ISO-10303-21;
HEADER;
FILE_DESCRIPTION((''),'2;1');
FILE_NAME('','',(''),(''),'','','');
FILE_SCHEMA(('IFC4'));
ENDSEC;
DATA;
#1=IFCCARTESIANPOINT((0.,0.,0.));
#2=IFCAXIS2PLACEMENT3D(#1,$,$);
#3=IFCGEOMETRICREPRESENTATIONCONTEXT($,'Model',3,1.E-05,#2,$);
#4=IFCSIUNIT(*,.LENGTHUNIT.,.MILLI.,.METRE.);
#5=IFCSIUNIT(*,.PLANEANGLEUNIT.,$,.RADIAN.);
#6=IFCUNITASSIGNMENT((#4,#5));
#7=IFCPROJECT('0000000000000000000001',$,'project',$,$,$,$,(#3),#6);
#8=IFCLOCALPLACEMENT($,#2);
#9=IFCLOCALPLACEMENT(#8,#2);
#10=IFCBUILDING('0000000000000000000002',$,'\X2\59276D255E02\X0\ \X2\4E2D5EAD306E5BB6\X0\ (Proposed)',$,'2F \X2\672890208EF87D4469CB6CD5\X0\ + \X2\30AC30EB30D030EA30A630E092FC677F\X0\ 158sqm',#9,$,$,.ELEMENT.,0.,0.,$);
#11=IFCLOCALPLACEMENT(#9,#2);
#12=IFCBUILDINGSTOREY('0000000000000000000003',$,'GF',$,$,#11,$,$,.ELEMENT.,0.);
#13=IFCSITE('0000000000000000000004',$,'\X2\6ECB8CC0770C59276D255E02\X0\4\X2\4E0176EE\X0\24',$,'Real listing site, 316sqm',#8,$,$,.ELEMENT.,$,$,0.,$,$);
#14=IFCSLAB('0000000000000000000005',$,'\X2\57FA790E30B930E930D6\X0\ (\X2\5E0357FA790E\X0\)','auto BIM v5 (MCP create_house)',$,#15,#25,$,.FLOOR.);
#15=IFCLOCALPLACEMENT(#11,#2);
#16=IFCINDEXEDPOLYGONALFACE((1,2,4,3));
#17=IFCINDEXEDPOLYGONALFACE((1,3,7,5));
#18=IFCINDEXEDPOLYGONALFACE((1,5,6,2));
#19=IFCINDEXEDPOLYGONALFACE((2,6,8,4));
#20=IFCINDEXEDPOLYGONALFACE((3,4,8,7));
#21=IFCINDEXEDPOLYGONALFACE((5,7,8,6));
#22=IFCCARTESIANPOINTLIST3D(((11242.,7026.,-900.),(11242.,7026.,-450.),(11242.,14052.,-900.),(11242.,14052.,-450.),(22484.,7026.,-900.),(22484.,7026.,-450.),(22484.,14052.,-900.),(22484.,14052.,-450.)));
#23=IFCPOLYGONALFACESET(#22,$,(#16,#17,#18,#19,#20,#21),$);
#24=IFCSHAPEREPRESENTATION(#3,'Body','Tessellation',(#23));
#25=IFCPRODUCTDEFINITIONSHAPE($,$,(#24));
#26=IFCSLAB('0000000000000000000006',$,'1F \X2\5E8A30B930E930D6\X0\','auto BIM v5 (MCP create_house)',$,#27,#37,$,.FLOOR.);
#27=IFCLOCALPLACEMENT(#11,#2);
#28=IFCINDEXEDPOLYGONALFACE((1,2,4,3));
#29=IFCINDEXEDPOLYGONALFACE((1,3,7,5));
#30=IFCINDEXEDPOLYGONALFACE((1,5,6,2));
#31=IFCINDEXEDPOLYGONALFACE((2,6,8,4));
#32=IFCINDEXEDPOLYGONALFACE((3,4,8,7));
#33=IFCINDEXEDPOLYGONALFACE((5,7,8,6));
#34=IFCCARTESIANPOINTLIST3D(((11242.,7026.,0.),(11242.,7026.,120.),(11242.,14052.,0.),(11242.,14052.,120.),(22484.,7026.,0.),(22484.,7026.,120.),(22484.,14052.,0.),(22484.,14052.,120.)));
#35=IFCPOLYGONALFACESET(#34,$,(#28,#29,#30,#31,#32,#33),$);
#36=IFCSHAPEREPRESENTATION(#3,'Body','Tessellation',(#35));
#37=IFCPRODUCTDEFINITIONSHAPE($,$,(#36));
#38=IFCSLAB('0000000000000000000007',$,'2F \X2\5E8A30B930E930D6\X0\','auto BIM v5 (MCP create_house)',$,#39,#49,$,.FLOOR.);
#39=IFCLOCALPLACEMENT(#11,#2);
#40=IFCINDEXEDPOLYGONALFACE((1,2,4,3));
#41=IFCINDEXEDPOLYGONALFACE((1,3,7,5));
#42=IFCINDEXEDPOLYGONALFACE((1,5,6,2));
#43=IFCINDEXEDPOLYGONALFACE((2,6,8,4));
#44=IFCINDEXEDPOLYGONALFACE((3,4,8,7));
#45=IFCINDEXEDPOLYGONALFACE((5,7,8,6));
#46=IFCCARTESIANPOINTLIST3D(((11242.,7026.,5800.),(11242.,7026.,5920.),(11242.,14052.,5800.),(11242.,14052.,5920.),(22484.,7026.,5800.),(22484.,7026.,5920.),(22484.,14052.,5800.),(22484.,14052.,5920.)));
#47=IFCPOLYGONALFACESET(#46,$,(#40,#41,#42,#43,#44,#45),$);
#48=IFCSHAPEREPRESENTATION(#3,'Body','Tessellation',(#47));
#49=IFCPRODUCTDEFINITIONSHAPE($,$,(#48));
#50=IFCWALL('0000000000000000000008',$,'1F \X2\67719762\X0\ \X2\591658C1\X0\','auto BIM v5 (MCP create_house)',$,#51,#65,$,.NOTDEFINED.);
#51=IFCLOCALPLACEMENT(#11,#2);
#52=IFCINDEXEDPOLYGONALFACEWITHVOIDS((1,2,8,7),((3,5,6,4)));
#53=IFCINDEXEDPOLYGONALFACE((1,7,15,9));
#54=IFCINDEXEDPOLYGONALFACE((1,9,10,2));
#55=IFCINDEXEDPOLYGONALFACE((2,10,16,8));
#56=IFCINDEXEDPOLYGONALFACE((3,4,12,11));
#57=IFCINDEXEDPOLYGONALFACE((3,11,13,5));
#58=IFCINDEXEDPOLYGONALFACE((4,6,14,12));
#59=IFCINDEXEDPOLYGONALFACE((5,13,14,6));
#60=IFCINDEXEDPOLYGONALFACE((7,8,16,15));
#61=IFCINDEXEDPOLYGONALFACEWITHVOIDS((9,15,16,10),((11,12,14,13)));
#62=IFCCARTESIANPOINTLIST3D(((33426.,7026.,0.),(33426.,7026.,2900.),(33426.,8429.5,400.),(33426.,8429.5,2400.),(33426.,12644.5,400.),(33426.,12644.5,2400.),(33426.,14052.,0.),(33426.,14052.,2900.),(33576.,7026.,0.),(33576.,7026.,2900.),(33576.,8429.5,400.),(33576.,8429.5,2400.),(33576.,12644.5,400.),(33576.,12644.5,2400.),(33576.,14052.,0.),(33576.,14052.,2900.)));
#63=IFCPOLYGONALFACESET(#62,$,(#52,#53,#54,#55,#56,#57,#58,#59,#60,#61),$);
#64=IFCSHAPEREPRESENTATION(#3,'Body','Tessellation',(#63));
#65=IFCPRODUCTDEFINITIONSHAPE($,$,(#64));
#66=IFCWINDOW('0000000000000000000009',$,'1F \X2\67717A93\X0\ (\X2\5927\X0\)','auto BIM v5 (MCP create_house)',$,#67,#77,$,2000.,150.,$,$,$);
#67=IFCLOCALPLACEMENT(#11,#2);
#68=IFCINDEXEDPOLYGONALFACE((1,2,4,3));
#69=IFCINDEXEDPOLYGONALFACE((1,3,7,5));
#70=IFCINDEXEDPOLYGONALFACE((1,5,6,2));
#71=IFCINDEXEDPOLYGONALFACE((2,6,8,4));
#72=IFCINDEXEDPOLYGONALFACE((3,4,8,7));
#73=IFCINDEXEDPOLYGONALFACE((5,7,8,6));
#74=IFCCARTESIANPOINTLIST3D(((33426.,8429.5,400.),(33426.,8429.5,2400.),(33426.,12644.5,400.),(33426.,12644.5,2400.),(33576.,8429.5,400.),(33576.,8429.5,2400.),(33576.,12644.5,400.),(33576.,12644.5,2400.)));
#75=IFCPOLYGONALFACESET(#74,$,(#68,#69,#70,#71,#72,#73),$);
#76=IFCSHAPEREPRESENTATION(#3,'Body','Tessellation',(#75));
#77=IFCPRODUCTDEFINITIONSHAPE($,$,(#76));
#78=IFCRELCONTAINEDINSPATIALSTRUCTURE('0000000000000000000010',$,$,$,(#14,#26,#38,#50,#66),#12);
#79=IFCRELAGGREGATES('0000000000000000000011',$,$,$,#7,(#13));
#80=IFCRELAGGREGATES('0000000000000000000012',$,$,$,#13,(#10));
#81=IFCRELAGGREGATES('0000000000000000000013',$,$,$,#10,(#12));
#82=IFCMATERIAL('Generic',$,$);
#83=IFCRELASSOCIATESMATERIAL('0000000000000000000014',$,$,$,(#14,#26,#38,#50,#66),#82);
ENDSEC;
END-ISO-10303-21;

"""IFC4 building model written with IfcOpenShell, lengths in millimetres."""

from ifc_helpers import new_model, si_unit, frame, frame_2d, origin, place, context, project, spatial, rectangle, extrude, material, element, fill, save


model = new_model("IFC4")

# Units and contexts
model_context = context("Model", 3, precision=1e-05, world=origin())
ifc_project = project(units=[si_unit("LENGTHUNIT", "METRE", prefix="MILLI"), si_unit("PLANEANGLEUNIT", "RADIAN")], contexts=[model_context])

# Site, building, storey
site_placement = place(None, origin())
site = spatial("IfcSite", under=ifc_project, at=site_placement, Name="滋賀県大津市4丁目24", ObjectType="Real listing site, 316sqm", CompositionType="ELEMENT", RefElevation=0.0)
building_placement = place(site_placement, origin())
building = spatial("IfcBuilding", under=site, at=building_placement, Name="大津市 中庭の家 (Proposed)", ObjectType="2F 木造軸組構法 + ガルバリウム鋼板 158sqm", CompositionType="ELEMENT", ElevationOfRefHeight=0.0, ElevationOfTerrain=0.0)
storey_placement = place(building_placement, origin())
storey = spatial("IfcBuildingStorey", under=building, at=storey_placement, Name="GF", CompositionType="ELEMENT", Elevation=0.0)

# Slabs
ifc_material = material(Name="Generic")
slab_1_placement = place(storey_placement, frame((5621.0, 3513.0, -450.0)))
element("IfcSlab", 1, at=slab_1_placement, inside=storey, material=ifc_material, Name="基礎スラブ (布基礎)", Description="auto BIM v5 (MCP create_house)", PredefinedType="FLOOR", context=model_context, shape_type="SweptSolid", body=[
    extrude(rectangle(XDim=11242.0, YDim=7026.0, at=frame_2d((5621.0, 3513.0))), frame((5621.0, 3513.0, -450.0)), (0.0, 0.0, 1.0), 450.0),
])
slab_2_placement = place(storey_placement, frame((5621.0, 3513.0, 0.0)))
element("IfcSlab", 2, at=slab_2_placement, inside=storey, material=ifc_material, Name="1F 床スラブ", Description="auto BIM v5 (MCP create_house)", PredefinedType="FLOOR", context=model_context, shape_type="SweptSolid", body=[
    extrude(rectangle(XDim=11242.0, YDim=7026.0, at=frame_2d((5621.0, 3513.0))), frame((5621.0, 3513.0, 0.0)), (0.0, 0.0, 1.0), 120.0),
])
slab_3_placement = place(storey_placement, frame((5621.0, 3513.0, 2900.0)))
element("IfcSlab", 3, at=slab_3_placement, inside=storey, material=ifc_material, Name="2F 床スラブ", Description="auto BIM v5 (MCP create_house)", PredefinedType="FLOOR", context=model_context, shape_type="SweptSolid", body=[
    extrude(rectangle(XDim=11242.0, YDim=7026.0, at=frame_2d((5621.0, 3513.0))), frame((5621.0, 3513.0, 2900.0)), (0.0, 0.0, 1.0), 120.0),
])

# Wall, opening, window
wall_1_placement = place(storey_placement, frame((16713.0, 3513.0, 0.0)))
wall_1 = element("IfcWall", 4, at=wall_1_placement, inside=storey, material=ifc_material, Name="1F 東面 外壁", Description="auto BIM v5 (MCP create_house)", PredefinedType="NOTDEFINED", context=model_context, shape_type="SweptSolid", body=[
    extrude(rectangle(XDim=150.0, YDim=7026.0, at=frame_2d((75.0, 3513.0))), frame((16713.0, 3513.0, 0.0)), (0.0, 0.0, 1.0), 2900.0),
])
opening_1_placement = place(storey_placement, frame((16713.0, 4215.0, 200.0)))
opening_1 = element("IfcOpeningElement", 5, at=opening_1_placement, cuts=wall_1, PredefinedType="NOTDEFINED", context=model_context, shape_type="SweptSolid", body=[
    extrude(rectangle(XDim=150.0, YDim=4215.0, at=frame_2d((75.0, 2107.0))), frame((16713.0, 4215.0, 200.0)), (0.0, 0.0, 1.0), 2000.0),
])
window_1_placement = place(storey_placement, frame((16713.0, 4215.0, 200.0)))
window_1 = element("IfcWindow", 6, at=window_1_placement, inside=storey, material=ifc_material, Name="1F 東窓 (大)", Description="auto BIM v5 (MCP create_house)", OverallHeight=2000.0, OverallWidth=150.0, context=model_context, shape_type="SweptSolid", body=[
    extrude(rectangle(XDim=150.0, YDim=4215.0, at=frame_2d((75.0, 2107.0))), frame((16713.0, 4215.0, 200.0)), (0.0, 0.0, 1.0), 2000.0),
])
fill(opening_1, window_1)

save(model, "model.ifc")
